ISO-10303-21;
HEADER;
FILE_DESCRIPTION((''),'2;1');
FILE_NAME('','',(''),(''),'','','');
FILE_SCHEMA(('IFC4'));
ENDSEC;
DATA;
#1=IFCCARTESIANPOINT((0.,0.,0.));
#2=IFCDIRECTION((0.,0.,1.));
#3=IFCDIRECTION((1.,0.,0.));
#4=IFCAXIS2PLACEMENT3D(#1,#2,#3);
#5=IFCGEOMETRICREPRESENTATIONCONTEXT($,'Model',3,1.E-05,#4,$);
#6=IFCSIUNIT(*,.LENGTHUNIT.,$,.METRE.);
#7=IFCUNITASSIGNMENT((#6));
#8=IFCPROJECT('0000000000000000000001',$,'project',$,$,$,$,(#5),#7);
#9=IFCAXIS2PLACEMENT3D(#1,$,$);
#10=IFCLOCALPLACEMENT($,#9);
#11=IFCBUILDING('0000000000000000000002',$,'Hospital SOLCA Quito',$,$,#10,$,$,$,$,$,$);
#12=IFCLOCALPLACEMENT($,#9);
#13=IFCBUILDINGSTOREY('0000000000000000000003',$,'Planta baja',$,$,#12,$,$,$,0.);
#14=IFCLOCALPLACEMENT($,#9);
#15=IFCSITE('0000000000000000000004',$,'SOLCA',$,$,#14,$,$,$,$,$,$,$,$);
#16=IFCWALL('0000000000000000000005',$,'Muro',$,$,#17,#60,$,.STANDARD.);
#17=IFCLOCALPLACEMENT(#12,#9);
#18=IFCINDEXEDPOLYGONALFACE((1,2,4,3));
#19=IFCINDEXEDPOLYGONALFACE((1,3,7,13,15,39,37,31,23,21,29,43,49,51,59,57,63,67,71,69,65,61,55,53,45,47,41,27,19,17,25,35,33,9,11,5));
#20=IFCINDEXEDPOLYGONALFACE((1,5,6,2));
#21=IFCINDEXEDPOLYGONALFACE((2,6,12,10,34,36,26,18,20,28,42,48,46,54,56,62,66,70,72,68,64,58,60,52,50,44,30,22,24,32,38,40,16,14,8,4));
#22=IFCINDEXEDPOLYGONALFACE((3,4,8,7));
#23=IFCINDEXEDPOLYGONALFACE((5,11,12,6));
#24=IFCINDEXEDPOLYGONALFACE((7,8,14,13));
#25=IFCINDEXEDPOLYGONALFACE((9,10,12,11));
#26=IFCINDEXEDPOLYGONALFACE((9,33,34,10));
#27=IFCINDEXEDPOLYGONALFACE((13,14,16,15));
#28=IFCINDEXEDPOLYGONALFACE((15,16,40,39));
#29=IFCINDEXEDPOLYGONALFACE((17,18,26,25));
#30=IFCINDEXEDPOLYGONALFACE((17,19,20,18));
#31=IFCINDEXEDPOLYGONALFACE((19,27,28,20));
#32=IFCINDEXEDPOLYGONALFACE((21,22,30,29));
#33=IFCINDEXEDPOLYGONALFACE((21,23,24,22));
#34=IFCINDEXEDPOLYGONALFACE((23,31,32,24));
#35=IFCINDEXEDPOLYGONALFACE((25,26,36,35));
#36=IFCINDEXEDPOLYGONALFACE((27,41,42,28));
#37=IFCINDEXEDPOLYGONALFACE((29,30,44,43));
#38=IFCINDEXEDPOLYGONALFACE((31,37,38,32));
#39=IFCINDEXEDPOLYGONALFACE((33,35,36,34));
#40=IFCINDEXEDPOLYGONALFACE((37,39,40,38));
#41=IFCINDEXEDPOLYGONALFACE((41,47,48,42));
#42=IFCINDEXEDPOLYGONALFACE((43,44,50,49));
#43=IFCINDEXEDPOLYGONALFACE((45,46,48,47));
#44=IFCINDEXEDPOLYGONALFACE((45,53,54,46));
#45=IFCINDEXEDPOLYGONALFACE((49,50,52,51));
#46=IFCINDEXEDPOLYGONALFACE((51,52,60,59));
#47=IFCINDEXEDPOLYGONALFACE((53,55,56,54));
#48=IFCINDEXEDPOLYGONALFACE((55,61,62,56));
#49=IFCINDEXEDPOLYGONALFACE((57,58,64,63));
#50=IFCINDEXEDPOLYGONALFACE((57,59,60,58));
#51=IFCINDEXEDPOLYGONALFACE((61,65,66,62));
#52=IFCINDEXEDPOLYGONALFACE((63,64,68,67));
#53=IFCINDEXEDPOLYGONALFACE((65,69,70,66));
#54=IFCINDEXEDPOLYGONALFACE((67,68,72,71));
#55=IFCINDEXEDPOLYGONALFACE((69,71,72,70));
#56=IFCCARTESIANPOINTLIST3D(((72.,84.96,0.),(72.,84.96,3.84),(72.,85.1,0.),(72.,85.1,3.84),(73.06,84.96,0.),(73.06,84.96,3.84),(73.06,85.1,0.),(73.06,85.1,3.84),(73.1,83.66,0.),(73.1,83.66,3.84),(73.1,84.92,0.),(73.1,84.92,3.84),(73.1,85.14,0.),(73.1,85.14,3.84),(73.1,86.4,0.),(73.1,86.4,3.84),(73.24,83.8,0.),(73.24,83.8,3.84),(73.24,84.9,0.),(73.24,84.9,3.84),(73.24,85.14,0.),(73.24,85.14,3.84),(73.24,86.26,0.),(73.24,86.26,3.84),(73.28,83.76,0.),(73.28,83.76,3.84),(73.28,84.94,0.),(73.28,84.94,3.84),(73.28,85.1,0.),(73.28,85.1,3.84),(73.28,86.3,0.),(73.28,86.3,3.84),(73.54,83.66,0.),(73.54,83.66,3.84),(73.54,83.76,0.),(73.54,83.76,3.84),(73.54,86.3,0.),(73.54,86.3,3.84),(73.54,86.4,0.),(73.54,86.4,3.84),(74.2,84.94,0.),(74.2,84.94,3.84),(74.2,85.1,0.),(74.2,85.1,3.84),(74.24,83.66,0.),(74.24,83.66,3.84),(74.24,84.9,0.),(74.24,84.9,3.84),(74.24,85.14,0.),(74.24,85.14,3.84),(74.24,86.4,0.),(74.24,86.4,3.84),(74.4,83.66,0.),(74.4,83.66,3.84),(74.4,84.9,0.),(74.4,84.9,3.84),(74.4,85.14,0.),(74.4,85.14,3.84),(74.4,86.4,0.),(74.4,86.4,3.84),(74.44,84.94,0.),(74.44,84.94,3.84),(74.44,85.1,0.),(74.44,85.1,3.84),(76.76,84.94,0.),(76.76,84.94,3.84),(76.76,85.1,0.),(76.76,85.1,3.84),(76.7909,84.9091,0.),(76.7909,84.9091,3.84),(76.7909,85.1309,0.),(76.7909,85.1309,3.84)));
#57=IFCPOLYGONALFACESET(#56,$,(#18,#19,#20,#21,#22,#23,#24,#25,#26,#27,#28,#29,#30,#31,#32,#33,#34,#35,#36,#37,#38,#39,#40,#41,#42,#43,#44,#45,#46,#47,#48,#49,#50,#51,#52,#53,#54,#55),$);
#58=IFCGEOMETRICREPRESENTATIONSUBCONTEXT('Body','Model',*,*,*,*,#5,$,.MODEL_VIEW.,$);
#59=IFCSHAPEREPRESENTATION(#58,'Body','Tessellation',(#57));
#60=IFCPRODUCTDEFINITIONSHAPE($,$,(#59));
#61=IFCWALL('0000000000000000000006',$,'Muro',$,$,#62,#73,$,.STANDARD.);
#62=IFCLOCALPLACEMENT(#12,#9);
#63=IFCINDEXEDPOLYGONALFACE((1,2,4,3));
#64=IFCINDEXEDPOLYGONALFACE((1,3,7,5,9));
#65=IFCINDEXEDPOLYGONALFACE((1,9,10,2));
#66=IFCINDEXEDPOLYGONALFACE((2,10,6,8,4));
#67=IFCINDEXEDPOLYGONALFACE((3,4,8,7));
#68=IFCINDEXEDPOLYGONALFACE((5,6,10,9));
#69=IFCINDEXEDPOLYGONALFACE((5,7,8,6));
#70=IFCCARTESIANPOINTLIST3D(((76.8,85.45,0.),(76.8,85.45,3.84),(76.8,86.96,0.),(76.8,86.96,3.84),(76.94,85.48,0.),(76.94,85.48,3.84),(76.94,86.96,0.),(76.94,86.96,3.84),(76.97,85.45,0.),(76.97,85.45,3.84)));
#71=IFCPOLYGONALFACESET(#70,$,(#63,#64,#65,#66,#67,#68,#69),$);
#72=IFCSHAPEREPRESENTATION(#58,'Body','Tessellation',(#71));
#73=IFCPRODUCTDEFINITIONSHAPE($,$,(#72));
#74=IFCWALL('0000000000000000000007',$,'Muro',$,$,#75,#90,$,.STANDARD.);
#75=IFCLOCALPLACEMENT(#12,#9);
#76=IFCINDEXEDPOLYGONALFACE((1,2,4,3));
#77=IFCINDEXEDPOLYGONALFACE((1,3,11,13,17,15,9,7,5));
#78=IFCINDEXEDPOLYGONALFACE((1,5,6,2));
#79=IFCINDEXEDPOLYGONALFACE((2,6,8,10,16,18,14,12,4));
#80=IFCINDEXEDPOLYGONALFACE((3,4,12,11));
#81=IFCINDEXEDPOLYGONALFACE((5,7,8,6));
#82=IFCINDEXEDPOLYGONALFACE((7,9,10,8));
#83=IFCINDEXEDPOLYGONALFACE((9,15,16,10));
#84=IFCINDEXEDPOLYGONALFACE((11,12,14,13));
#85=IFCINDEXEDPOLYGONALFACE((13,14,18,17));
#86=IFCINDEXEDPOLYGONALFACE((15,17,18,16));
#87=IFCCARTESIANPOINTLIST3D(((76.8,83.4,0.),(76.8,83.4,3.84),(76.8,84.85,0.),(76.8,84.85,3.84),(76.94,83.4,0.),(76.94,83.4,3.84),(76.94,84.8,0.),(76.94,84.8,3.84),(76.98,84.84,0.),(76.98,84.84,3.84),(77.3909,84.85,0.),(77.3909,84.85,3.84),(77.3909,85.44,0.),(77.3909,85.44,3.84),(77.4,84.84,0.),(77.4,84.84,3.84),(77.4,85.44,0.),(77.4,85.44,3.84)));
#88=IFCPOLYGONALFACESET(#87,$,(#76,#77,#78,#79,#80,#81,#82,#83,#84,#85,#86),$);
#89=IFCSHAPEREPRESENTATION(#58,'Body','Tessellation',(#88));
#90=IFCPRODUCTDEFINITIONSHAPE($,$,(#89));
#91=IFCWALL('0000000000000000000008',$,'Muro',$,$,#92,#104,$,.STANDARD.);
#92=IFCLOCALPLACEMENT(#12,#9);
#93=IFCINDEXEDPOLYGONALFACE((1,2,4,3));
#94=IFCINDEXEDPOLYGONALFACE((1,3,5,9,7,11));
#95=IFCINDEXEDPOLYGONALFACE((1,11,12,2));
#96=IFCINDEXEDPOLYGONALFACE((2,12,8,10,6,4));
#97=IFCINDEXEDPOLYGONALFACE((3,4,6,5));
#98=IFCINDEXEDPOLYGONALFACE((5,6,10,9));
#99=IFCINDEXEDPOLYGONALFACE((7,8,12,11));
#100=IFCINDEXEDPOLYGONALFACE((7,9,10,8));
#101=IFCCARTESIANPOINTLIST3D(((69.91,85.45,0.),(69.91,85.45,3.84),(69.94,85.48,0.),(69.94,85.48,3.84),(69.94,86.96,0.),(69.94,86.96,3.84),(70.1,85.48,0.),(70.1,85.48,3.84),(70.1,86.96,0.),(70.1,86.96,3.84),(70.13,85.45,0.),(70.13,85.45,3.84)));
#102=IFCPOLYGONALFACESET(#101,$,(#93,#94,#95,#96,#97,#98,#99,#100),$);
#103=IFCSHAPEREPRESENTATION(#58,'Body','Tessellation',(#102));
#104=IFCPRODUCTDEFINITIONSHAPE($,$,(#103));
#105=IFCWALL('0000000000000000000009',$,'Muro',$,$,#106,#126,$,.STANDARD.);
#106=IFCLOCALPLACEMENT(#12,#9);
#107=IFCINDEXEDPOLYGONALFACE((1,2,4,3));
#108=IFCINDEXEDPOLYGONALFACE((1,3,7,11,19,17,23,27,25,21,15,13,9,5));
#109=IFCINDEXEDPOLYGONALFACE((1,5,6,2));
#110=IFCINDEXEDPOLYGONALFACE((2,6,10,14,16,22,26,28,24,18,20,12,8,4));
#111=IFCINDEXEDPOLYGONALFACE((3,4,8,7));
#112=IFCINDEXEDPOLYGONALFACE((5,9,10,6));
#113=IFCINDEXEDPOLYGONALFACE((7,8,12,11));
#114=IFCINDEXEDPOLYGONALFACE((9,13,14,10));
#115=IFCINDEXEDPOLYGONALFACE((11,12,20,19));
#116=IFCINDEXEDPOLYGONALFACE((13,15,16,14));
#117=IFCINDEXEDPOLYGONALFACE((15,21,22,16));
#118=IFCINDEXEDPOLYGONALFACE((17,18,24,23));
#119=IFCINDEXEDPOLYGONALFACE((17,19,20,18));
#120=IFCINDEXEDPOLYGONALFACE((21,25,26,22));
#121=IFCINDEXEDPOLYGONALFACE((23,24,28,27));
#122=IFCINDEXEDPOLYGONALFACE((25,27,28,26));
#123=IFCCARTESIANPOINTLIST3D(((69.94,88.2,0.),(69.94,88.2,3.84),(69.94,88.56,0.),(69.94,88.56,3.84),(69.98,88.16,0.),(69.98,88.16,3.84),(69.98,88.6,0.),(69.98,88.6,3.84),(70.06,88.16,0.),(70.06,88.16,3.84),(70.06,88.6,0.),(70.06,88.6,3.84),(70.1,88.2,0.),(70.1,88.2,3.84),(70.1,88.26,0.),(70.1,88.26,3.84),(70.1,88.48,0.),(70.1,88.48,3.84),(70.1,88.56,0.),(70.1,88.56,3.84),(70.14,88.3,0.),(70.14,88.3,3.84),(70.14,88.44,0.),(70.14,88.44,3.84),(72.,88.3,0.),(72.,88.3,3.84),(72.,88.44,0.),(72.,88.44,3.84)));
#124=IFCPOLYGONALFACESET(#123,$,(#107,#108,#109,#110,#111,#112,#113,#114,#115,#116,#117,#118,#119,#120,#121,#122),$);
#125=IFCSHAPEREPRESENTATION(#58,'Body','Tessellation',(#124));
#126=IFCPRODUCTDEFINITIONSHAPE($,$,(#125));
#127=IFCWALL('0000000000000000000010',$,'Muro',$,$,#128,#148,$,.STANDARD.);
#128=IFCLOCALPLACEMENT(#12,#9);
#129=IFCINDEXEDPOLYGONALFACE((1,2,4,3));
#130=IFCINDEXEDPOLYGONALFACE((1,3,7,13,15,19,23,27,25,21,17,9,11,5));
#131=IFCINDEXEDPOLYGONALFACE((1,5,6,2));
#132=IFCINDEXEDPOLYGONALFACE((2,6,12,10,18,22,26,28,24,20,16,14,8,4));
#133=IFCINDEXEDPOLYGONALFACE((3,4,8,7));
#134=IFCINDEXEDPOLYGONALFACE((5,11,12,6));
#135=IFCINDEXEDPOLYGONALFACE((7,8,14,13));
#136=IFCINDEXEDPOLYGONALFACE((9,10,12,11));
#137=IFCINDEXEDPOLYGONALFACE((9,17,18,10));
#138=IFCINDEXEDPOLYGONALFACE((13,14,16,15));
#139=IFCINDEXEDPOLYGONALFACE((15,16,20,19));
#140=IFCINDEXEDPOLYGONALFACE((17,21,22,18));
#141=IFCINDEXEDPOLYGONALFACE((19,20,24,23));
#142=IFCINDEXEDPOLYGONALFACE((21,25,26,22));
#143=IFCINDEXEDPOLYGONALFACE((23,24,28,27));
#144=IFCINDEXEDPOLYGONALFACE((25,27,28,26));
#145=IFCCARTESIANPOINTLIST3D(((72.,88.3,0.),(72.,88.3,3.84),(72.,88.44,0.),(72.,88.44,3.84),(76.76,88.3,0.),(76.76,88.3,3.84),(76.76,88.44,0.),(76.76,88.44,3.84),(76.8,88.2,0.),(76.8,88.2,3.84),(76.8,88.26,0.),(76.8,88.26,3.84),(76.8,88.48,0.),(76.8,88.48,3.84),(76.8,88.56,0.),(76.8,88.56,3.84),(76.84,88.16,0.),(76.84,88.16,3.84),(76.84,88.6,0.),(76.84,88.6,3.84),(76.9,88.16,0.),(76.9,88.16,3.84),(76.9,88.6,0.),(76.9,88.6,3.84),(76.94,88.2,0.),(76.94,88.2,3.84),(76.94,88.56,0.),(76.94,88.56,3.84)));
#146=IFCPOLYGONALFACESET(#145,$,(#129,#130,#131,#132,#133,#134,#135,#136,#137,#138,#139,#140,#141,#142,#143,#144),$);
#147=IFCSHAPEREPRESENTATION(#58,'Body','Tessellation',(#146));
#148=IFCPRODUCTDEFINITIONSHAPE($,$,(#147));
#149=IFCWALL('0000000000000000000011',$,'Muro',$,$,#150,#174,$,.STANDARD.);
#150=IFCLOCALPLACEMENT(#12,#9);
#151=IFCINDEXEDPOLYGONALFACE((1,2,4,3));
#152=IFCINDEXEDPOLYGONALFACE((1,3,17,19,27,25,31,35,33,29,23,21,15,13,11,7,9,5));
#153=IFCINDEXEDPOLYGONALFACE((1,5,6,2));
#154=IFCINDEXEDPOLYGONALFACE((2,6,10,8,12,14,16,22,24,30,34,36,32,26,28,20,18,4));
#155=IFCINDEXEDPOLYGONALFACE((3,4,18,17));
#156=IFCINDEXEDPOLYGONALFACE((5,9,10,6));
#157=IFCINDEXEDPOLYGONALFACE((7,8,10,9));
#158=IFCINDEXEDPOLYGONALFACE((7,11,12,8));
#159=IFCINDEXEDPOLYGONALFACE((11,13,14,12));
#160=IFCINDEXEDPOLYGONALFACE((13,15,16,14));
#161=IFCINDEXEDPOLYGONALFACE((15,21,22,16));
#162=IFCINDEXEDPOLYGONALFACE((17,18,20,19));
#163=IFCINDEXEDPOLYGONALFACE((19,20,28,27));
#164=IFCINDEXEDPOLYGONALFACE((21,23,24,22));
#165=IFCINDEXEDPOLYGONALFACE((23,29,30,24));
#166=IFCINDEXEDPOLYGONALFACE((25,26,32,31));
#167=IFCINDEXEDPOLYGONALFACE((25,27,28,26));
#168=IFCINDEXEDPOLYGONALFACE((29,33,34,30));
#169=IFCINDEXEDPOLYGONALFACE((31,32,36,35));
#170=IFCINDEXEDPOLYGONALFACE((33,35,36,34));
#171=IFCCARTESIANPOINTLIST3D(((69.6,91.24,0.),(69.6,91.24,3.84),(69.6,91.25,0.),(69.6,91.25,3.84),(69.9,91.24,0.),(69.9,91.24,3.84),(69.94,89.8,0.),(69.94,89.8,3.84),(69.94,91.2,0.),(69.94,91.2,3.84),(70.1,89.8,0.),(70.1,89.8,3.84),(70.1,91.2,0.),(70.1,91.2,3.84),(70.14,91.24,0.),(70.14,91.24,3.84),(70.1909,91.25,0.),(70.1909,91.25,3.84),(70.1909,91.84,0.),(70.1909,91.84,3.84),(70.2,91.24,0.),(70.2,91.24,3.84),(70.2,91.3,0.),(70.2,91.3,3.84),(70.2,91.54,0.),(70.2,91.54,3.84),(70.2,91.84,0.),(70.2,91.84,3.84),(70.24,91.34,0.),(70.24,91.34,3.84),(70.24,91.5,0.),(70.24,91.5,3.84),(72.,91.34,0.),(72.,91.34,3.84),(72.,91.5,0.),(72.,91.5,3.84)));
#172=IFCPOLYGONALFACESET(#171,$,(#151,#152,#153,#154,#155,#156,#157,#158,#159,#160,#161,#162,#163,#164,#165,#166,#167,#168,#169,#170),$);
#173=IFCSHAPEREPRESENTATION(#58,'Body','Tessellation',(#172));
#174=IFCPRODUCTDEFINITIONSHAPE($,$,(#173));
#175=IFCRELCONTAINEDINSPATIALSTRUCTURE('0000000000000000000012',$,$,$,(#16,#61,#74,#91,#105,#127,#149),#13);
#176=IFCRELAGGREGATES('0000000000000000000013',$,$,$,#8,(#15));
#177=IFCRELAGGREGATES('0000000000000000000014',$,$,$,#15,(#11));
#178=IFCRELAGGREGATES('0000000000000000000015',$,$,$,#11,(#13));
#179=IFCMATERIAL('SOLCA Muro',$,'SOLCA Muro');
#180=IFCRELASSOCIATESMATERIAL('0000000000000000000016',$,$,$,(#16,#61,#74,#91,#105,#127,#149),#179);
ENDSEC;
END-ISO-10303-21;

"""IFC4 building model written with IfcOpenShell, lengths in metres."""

from ifc_helpers import new_model, si_unit, origin, origin_with_axes, place, context, subcontext, project, spatial, polyline, outline, extrude, material, element, save


model = new_model("IFC4")

# Units and contexts
model_context = context("Model", 3, precision=1e-05, world=origin_with_axes())
body_context = subcontext(model_context, "Body", "Model", "MODEL_VIEW")
ifc_project = project(units=[si_unit("LENGTHUNIT", "METRE")], contexts=[model_context])

# Site, building, storey
site_placement = place(None, origin())
site = spatial("IfcSite", under=ifc_project, at=site_placement, Name="SOLCA")
building_placement = place(None, origin())
building = spatial("IfcBuilding", under=site, at=building_placement, Name="Hospital SOLCA Quito")
storey_placement = place(None, origin())
storey = spatial("IfcBuildingStorey", under=building, at=storey_placement, Name="Planta baja", Elevation=0.0)

# Walls
ifc_material = material(Name="SOLCA Muro", Category="SOLCA Muro")
wall_1_placement = place(storey_placement, origin_with_axes())
element("IfcWall", 1, at=wall_1_placement, inside=storey, material=ifc_material, Name="Muro", PredefinedType="STANDARD", context=body_context, shape_type="SweptSolid", body=[
    extrude(outline(polyline([(74.24, 86.4), (74.4, 86.4), (74.4, 85.14), (74.44, 85.1), (76.76, 85.1), (76.7909, 85.1309), (76.7909, 84.9091), (76.76, 84.94), (74.44, 84.94), (74.4, 84.9), (74.4, 83.66), (74.24, 83.66), (74.24, 84.9), (74.2, 84.94), (73.28, 84.94), (73.24, 84.9), (73.24, 83.8), (73.28, 83.76), (73.54, 83.76), (73.54, 83.66), (73.1, 83.66), (73.1, 84.92), (73.06, 84.96), (72.0, 84.96), (72.0, 85.1), (73.06, 85.1), (73.1, 85.14), (73.1, 86.4), (73.54, 86.4), (73.54, 86.3), (73.28, 86.3), (73.24, 86.26), (73.24, 85.14), (73.28, 85.1), (74.2, 85.1), (74.24, 85.14), (74.24, 86.4)])), origin_with_axes(), (0.0, 0.0, 1.0), 3.84),
])
wall_2_placement = place(storey_placement, origin_with_axes())
element("IfcWall", 2, at=wall_2_placement, inside=storey, material=ifc_material, Name="Muro", PredefinedType="STANDARD", context=body_context, shape_type="SweptSolid", body=[
    extrude(outline(polyline([(76.94, 86.96), (76.94, 85.48), (76.97, 85.45), (76.8, 85.45), (76.8, 86.96), (76.94, 86.96)])), origin_with_axes(), (0.0, 0.0, 1.0), 3.84),
])
wall_3_placement = place(storey_placement, origin_with_axes())
element("IfcWall", 3, at=wall_3_placement, inside=storey, material=ifc_material, Name="Muro", PredefinedType="STANDARD", context=body_context, shape_type="SweptSolid", body=[
    extrude(outline(polyline([(76.98, 84.84), (76.94, 84.8), (76.94, 83.4), (76.8, 83.4), (76.8, 84.85), (77.3909, 84.85), (77.3909, 85.44), (77.4, 85.44), (77.4, 84.84), (76.98, 84.84)])), origin_with_axes(), (0.0, 0.0, 1.0), 3.84),
])
wall_4_placement = place(storey_placement, origin_with_axes())
element("IfcWall", 4, at=wall_4_placement, inside=storey, material=ifc_material, Name="Muro", PredefinedType="STANDARD", context=body_context, shape_type="SweptSolid", body=[
    extrude(outline(polyline([(69.91, 85.45), (69.94, 85.48), (69.94, 86.96), (70.1, 86.96), (70.1, 85.48), (70.13, 85.45), (69.91, 85.45)])), origin_with_axes(), (0.0, 0.0, 1.0), 3.84),
])
wall_5_placement = place(storey_placement, origin_with_axes())
element("IfcWall", 5, at=wall_5_placement, inside=storey, material=ifc_material, Name="Muro", PredefinedType="STANDARD", context=body_context, shape_type="SweptSolid", body=[
    extrude(outline(polyline([(70.1, 88.2), (70.06, 88.16), (69.98, 88.16), (69.94, 88.2), (69.94, 88.56), (69.98, 88.6), (70.06, 88.6), (70.1, 88.56), (70.1, 88.48), (70.14, 88.44), (72.0, 88.44), (72.0, 88.3), (70.14, 88.3), (70.1, 88.26), (70.1, 88.2)])), origin_with_axes(), (0.0, 0.0, 1.0), 3.84),
])
wall_6_placement = place(storey_placement, origin_with_axes())
element("IfcWall", 6, at=wall_6_placement, inside=storey, material=ifc_material, Name="Muro", PredefinedType="STANDARD", context=body_context, shape_type="SweptSolid", body=[
    extrude(outline(polyline([(76.76, 88.44), (76.8, 88.48), (76.8, 88.56), (76.84, 88.6), (76.9, 88.6), (76.94, 88.56), (76.94, 88.2), (76.9, 88.16), (76.84, 88.16), (76.8, 88.2), (76.8, 88.26), (76.76, 88.3), (72.0, 88.3), (72.0, 88.44), (76.76, 88.44)])), origin_with_axes(), (0.0, 0.0, 1.0), 3.84),
])
wall_7_placement = place(storey_placement, origin_with_axes())
element("IfcWall", 7, at=wall_7_placement, inside=storey, material=ifc_material, Name="Muro", PredefinedType="STANDARD", context=body_context, shape_type="SweptSolid", body=[
    extrude(outline(polyline([(70.24, 91.34), (70.2, 91.3), (70.2, 91.24), (70.14, 91.24), (70.1, 91.2), (70.1, 89.8), (69.94, 89.8), (69.94, 91.2), (69.9, 91.24), (69.6, 91.24), (69.6, 91.25), (70.1909, 91.25), (70.1909, 91.84), (70.2, 91.84), (70.2, 91.54), (70.24, 91.5), (72.0, 91.5), (72.0, 91.34), (70.24, 91.34)])), origin_with_axes(), (0.0, 0.0, 1.0), 3.84),
])

save(model, "model.ifc")
